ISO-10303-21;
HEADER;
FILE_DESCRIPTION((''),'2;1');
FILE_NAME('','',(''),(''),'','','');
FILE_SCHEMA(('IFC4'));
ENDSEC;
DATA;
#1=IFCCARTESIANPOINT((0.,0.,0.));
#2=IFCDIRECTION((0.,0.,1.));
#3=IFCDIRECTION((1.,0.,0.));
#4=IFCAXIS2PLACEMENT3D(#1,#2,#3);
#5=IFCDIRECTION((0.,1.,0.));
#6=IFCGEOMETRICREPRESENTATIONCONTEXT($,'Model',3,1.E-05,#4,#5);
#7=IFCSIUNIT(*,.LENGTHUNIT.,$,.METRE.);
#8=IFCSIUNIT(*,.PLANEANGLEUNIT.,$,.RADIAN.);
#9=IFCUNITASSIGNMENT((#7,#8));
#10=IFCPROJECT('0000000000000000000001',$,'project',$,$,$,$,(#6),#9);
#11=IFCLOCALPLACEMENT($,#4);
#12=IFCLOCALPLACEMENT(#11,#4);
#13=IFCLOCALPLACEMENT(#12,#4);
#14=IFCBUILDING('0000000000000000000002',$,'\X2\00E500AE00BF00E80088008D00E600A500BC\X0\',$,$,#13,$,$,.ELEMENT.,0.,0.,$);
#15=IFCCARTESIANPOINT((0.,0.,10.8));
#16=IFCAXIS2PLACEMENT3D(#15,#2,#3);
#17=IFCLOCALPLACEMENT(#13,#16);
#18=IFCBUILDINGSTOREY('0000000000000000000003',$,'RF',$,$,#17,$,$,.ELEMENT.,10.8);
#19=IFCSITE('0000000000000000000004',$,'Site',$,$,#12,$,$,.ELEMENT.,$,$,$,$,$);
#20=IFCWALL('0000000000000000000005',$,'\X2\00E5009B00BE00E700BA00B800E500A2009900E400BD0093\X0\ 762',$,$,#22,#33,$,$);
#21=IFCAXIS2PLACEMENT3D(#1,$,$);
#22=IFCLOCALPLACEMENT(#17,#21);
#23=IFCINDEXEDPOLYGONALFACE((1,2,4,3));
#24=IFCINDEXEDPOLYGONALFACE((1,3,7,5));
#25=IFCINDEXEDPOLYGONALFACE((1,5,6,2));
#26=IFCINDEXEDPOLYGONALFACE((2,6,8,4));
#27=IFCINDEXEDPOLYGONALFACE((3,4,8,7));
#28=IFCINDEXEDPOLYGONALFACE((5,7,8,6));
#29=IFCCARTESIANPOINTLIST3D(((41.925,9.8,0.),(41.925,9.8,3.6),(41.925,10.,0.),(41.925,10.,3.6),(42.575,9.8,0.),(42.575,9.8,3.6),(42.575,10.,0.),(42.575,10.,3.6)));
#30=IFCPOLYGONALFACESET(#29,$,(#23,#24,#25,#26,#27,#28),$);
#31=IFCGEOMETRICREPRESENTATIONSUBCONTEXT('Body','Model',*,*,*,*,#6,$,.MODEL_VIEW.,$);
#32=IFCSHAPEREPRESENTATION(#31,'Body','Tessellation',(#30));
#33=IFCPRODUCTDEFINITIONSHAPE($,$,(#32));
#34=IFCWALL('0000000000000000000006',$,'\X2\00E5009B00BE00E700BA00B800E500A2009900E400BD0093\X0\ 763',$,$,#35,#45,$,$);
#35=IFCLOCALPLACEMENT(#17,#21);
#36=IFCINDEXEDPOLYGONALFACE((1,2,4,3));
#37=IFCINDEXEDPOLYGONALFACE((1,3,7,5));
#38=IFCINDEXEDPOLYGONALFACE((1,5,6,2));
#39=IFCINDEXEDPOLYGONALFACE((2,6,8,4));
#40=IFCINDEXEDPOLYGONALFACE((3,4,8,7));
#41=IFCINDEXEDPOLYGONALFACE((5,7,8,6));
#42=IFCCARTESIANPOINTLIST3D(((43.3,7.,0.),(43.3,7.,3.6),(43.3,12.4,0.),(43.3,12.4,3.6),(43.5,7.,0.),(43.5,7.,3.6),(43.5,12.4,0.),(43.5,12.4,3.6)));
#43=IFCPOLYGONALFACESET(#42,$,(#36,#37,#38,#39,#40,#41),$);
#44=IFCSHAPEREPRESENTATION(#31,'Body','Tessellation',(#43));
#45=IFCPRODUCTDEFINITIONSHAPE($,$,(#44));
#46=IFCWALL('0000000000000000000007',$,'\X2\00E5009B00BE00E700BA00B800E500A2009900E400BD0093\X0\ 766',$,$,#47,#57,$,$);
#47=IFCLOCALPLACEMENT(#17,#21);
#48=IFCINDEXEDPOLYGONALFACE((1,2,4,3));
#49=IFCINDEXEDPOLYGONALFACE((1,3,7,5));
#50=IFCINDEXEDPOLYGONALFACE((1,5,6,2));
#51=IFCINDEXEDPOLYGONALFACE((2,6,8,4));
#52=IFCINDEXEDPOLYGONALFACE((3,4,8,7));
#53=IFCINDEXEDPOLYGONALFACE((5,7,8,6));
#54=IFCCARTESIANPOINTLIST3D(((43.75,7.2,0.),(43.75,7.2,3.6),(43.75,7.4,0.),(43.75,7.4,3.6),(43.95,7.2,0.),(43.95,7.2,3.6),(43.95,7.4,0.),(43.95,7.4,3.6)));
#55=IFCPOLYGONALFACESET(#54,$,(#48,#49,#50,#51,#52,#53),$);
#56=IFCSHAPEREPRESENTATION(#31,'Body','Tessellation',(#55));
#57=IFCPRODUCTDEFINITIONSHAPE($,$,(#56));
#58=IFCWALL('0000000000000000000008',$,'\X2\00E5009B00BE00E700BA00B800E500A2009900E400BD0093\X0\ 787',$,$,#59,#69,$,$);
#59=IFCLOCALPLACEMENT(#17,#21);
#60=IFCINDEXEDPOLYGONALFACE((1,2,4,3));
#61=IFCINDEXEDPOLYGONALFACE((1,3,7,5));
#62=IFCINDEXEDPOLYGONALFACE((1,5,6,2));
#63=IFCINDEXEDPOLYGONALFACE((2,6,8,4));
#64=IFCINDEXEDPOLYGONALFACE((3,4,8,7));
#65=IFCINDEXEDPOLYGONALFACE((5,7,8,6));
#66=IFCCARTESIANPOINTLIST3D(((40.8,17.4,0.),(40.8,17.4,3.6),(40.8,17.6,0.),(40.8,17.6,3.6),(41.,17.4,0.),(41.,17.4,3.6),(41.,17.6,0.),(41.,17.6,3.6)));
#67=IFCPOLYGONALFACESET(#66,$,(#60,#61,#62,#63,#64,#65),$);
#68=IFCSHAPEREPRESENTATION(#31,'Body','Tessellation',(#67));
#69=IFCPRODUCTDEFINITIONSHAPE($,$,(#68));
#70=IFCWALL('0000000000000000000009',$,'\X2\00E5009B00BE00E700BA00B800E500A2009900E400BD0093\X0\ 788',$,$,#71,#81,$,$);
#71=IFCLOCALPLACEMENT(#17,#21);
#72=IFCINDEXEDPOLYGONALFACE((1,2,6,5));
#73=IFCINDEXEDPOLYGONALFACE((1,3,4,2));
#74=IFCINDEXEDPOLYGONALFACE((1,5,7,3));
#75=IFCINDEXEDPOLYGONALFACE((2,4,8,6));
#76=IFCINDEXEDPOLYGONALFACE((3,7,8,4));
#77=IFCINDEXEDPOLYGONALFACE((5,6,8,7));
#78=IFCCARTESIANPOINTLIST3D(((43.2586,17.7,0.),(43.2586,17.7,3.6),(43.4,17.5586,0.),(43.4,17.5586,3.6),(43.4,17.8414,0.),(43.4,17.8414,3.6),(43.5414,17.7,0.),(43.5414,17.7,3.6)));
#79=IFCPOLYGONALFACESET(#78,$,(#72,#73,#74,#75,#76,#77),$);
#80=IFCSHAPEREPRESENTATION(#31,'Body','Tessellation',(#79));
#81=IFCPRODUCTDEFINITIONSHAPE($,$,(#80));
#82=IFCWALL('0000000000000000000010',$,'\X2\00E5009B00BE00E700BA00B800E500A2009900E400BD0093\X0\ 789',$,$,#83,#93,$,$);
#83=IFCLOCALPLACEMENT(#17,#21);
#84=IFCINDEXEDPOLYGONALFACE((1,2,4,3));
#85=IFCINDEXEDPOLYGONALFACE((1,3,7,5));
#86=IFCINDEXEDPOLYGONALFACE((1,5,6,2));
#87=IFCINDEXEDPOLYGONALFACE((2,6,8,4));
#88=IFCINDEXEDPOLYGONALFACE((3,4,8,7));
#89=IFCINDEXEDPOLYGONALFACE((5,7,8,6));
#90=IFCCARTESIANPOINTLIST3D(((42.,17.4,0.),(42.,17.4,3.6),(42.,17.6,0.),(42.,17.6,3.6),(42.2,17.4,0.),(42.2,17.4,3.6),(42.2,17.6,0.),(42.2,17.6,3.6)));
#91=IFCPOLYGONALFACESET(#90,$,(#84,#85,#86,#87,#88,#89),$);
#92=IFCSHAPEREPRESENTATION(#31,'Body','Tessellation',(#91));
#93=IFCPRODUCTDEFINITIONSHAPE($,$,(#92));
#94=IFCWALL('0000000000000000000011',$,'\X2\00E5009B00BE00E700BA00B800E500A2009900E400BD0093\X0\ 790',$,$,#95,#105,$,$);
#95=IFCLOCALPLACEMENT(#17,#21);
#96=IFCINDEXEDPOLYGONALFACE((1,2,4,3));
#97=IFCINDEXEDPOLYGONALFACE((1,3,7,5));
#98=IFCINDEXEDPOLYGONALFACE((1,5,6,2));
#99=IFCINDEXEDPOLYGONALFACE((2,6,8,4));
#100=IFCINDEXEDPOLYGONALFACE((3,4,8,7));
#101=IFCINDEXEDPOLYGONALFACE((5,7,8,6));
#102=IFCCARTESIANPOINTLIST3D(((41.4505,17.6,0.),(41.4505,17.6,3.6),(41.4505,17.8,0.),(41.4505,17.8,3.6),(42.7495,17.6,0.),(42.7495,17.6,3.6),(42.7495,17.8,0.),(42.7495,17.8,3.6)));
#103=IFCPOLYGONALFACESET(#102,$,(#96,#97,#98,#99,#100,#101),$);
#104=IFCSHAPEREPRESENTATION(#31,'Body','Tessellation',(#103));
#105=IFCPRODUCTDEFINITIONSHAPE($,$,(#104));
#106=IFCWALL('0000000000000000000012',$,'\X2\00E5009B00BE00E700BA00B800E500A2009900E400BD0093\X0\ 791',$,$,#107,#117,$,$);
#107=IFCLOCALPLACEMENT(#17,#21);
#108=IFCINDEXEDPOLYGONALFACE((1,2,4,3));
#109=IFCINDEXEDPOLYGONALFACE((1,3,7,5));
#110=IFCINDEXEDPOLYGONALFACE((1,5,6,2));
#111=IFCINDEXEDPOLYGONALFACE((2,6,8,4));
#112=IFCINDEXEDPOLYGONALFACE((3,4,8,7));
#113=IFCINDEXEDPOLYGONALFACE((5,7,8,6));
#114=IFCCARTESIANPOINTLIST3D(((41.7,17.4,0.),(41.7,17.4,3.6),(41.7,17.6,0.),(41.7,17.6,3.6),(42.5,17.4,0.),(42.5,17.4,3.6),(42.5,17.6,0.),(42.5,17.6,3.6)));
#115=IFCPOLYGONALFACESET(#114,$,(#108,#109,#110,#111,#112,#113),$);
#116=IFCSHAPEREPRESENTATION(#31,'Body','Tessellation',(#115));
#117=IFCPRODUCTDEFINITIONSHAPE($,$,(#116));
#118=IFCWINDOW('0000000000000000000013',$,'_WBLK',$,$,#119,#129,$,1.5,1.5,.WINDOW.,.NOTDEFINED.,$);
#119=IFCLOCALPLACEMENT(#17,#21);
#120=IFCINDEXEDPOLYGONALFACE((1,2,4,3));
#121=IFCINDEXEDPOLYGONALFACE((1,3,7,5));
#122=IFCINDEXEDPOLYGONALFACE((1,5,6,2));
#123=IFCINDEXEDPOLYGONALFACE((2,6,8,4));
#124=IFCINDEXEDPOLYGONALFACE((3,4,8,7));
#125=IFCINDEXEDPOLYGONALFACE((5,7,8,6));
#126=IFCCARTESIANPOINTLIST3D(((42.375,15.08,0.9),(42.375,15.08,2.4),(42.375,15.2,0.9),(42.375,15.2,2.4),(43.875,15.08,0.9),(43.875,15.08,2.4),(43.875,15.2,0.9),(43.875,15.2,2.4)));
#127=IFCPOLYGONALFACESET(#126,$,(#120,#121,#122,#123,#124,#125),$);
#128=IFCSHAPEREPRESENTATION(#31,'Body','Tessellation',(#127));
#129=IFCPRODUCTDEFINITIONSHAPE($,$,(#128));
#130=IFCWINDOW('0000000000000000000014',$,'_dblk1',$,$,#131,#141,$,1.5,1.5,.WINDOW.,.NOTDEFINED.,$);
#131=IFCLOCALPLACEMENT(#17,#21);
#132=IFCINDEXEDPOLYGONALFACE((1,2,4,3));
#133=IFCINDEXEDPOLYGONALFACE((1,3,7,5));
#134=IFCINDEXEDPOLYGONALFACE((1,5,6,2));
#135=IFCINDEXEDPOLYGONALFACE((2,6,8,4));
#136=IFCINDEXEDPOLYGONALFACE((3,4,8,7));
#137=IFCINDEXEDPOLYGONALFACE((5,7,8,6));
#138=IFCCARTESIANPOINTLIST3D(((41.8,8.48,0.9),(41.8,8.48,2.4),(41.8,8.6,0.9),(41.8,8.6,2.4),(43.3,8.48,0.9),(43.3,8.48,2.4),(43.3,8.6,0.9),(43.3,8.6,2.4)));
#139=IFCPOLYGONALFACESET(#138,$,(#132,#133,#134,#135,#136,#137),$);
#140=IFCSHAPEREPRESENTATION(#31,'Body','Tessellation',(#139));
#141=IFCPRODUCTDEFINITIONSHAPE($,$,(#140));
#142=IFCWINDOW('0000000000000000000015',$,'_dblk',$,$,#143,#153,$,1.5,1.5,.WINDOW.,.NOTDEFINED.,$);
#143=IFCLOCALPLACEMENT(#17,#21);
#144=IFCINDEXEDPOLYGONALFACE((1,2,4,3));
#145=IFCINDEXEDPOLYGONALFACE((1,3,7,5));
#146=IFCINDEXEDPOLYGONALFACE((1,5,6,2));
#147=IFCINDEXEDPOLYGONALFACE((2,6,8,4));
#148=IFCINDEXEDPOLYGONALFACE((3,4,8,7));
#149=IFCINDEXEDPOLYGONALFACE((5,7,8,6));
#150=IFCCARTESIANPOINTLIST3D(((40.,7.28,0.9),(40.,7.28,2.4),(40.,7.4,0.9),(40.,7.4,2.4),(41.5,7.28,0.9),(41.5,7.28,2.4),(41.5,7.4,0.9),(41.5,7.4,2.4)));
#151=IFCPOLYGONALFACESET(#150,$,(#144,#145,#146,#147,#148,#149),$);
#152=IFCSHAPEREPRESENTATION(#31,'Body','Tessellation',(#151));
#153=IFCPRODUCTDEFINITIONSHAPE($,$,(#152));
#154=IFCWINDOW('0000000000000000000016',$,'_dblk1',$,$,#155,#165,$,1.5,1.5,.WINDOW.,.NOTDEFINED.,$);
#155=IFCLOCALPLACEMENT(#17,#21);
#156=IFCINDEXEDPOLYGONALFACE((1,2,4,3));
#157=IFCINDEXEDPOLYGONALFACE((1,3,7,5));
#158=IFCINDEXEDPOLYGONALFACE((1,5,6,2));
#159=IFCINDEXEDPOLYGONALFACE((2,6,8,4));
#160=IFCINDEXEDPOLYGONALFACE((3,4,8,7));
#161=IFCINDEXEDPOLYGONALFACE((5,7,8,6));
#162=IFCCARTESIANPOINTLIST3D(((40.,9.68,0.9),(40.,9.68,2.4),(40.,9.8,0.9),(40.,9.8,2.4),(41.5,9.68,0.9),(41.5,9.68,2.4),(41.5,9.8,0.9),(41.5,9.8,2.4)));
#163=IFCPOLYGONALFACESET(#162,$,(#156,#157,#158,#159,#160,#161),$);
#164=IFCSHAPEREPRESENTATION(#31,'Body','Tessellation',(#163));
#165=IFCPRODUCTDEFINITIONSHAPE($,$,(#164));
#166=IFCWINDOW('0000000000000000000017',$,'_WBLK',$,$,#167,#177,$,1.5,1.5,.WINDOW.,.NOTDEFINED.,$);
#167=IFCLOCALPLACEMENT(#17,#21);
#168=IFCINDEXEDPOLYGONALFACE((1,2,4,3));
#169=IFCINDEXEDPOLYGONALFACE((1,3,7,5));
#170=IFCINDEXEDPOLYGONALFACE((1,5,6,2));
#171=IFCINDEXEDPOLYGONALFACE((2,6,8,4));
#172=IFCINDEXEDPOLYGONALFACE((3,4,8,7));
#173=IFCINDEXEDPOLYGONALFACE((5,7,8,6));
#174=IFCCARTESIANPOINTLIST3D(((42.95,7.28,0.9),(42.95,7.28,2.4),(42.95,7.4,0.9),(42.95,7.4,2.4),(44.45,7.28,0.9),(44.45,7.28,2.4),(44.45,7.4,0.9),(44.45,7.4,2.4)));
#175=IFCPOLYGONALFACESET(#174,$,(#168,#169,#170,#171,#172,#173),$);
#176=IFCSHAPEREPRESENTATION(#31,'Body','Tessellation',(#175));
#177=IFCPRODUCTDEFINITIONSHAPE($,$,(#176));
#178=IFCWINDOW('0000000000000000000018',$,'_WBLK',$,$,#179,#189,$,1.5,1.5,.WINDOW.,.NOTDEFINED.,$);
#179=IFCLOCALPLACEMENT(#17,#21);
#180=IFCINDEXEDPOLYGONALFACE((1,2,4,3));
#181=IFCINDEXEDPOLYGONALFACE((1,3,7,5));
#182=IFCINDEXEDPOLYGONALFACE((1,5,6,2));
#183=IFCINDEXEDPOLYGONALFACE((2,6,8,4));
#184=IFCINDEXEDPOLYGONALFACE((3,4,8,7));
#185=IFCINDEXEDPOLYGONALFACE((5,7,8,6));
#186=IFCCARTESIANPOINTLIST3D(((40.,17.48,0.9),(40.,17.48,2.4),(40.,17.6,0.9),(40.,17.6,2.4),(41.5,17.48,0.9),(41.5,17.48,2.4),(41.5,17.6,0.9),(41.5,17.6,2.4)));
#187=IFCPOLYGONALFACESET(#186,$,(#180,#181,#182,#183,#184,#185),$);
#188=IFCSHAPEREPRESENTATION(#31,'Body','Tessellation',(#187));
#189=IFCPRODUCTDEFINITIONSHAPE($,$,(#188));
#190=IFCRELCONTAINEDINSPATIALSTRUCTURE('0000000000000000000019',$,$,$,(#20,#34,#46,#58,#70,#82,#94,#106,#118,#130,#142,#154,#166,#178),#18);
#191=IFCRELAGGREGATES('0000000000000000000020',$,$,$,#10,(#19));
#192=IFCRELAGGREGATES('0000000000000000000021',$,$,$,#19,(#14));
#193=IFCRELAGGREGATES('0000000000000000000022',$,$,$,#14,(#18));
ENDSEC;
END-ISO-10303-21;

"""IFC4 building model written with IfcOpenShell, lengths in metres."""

from ifc_helpers import new_model, si_unit, direction, frame, frame_2d, origin_with_axes, place, context, subcontext, project, spatial, rectangle, extrude, element, save


model = new_model("IFC4")

# Units and contexts
model_context = context("Model", 3, precision=1e-05, world=origin_with_axes(), true_north=direction((0.0, 1.0, 0.0)))
body_context = subcontext(model_context, "Body", "Model", "MODEL_VIEW")
ifc_project = project(units=[si_unit("LENGTHUNIT", "METRE"), si_unit("PLANEANGLEUNIT", "RADIAN")], contexts=[model_context])

# Site, building, storey
placement = place(None, origin_with_axes())
site_placement = place(placement, origin_with_axes())
site = spatial("IfcSite", under=ifc_project, at=site_placement, Name="Site", CompositionType="ELEMENT")
building_placement = place(site_placement, origin_with_axes())
building = spatial("IfcBuilding", under=site, at=building_placement, Name="å®¿è\u0088\u008dæ¥¼", CompositionType="ELEMENT", ElevationOfRefHeight=0.0, ElevationOfTerrain=0.0)
storey_placement = place(building_placement, frame((0.0, 0.0, 10.8), z_axis=(0.0, 0.0, 1.0), x_axis=(1.0, 0.0, 0.0)))
storey = spatial("IfcBuildingStorey", under=building, at=storey_placement, Name="RF", CompositionType="ELEMENT", Elevation=10.8)

# Walls
wall_1_placement = place(storey_placement, frame((42.25, 9.9, 0.0), z_axis=(0.0, 0.0, 1.0), x_axis=(1.0, 0.0, 0.0)))
element("IfcWall", 1, at=wall_1_placement, inside=storey, Name="å\u009b¾çº¸å¢\u0099ä½\u0093 762", context=body_context, shape_type="SweptSolid", body=[
    extrude(rectangle(XDim=0.65, YDim=0.2, at=frame_2d((0.0, 0.0), x_axis=(1.0, 0.0, 0.0))), frame((0.0, 0.0, 0.0), z_axis=(0.0, 0.0, 1.0)), (0.0, 0.0, 1.0), 3.6),
])
wall_2_placement = place(storey_placement, frame((43.4, 9.7, 0.0), z_axis=(0.0, 0.0, 1.0), x_axis=(0.0, 1.0, 0.0)))
element("IfcWall", 2, at=wall_2_placement, inside=storey, Name="å\u009b¾çº¸å¢\u0099ä½\u0093 763", context=body_context, shape_type="SweptSolid", body=[
    extrude(rectangle(XDim=5.4, YDim=0.2, at=frame_2d((0.0, 0.0), x_axis=(1.0, 0.0, 0.0))), frame((0.0, 0.0, 0.0), z_axis=(0.0, 0.0, 1.0)), (0.0, 0.0, 1.0), 3.6),
])
for number, where, z_axis, x_axis, name in (
    (3, (43.85, 7.3, 0.0), (0.0, 0.0, 1.0), (0.0, 1.0, 0.0), "å\u009b¾çº¸å¢\u0099ä½\u0093 766"),
    (4, (40.9, 17.5, 0.0), (0.0, 0.0, 1.0), (0.0, 1.0, 0.0), "å\u009b¾çº¸å¢\u0099ä½\u0093 787"),
    (5, (43.4, 17.7, 0.0), (0.0, 0.0, 1.0), (0.707107, -0.707107, 0.0), "å\u009b¾çº¸å¢\u0099ä½\u0093 788"),
    (6, (42.1, 17.5, 0.0), (0.0, 0.0, 1.0), (0.0, 1.0, 0.0), "å\u009b¾çº¸å¢\u0099ä½\u0093 789"),
):
    element("IfcWall", number, at=place(storey_placement, frame(where, z_axis=z_axis, x_axis=x_axis)), inside=storey, Name=name, context=body_context, shape_type="SweptSolid", body=[
        extrude(rectangle(XDim=0.2, YDim=0.2, at=frame_2d((0.0, 0.0), x_axis=(1.0, 0.0, 0.0))), frame((0.0, 0.0, 0.0), z_axis=(0.0, 0.0, 1.0)), (0.0, 0.0, 1.0), 3.6),
    ])
wall_3_placement = place(storey_placement, frame((42.1, 17.7, 0.0), z_axis=(0.0, 0.0, 1.0), x_axis=(1.0, 0.0, 0.0)))
element("IfcWall", 7, at=wall_3_placement, inside=storey, Name="å\u009b¾çº¸å¢\u0099ä½\u0093 790", context=body_context, shape_type="SweptSolid", body=[
    extrude(rectangle(XDim=1.299, YDim=0.2, at=frame_2d((0.0, 0.0), x_axis=(1.0, 0.0, 0.0))), frame((0.0, 0.0, 0.0), z_axis=(0.0, 0.0, 1.0)), (0.0, 0.0, 1.0), 3.6),
])
wall_4_placement = place(storey_placement, frame((42.1, 17.5, 0.0), z_axis=(0.0, 0.0, 1.0), x_axis=(1.0, 0.0, 0.0)))
element("IfcWall", 8, at=wall_4_placement, inside=storey, Name="å\u009b¾çº¸å¢\u0099ä½\u0093 791", context=body_context, shape_type="SweptSolid", body=[
    extrude(rectangle(XDim=0.8, YDim=0.2, at=frame_2d((0.0, 0.0), x_axis=(1.0, 0.0, 0.0))), frame((0.0, 0.0, 0.0), z_axis=(0.0, 0.0, 1.0)), (0.0, 0.0, 1.0), 3.6),
])

# Windows
for number, where, z_axis, x_axis, name in (
    (9, (43.125, 15.14, 0.9), (0.0, 0.0, 1.0), (1.0, 0.0, 0.0), "_WBLK"),
    (10, (42.55, 8.54, 0.9), (0.0, 0.0, 1.0), (1.0, 0.0, 0.0), "_dblk1"),
    (11, (40.75, 7.34, 0.9), (0.0, 0.0, 1.0), (1.0, 0.0, 0.0), "_dblk"),
    (12, (40.75, 9.74, 0.9), (0.0, 0.0, 1.0), (1.0, 0.0, 0.0), "_dblk1"),
    (13, (43.7, 7.34, 0.9), (0.0, 0.0, 1.0), (1.0, 0.0, 0.0), "_WBLK"),
    (14, (40.75, 17.54, 0.9), (0.0, 0.0, 1.0), (1.0, 0.0, 0.0), "_WBLK"),
):
    element("IfcWindow", number, at=place(storey_placement, frame(where, z_axis=z_axis, x_axis=x_axis)), inside=storey, Name=name, OverallHeight=1.5, OverallWidth=1.5, PartitioningType="NOTDEFINED", PredefinedType="WINDOW", context=body_context, shape_type="SweptSolid", body=[
        extrude(rectangle(XDim=1.5, YDim=0.12, at=frame_2d((0.0, 0.0), x_axis=(1.0, 0.0, 0.0))), frame((0.0, 0.0, 0.0), z_axis=(0.0, 0.0, 1.0)), (0.0, 0.0, 1.0), 1.5),
    ])

save(model, "model.ifc")
